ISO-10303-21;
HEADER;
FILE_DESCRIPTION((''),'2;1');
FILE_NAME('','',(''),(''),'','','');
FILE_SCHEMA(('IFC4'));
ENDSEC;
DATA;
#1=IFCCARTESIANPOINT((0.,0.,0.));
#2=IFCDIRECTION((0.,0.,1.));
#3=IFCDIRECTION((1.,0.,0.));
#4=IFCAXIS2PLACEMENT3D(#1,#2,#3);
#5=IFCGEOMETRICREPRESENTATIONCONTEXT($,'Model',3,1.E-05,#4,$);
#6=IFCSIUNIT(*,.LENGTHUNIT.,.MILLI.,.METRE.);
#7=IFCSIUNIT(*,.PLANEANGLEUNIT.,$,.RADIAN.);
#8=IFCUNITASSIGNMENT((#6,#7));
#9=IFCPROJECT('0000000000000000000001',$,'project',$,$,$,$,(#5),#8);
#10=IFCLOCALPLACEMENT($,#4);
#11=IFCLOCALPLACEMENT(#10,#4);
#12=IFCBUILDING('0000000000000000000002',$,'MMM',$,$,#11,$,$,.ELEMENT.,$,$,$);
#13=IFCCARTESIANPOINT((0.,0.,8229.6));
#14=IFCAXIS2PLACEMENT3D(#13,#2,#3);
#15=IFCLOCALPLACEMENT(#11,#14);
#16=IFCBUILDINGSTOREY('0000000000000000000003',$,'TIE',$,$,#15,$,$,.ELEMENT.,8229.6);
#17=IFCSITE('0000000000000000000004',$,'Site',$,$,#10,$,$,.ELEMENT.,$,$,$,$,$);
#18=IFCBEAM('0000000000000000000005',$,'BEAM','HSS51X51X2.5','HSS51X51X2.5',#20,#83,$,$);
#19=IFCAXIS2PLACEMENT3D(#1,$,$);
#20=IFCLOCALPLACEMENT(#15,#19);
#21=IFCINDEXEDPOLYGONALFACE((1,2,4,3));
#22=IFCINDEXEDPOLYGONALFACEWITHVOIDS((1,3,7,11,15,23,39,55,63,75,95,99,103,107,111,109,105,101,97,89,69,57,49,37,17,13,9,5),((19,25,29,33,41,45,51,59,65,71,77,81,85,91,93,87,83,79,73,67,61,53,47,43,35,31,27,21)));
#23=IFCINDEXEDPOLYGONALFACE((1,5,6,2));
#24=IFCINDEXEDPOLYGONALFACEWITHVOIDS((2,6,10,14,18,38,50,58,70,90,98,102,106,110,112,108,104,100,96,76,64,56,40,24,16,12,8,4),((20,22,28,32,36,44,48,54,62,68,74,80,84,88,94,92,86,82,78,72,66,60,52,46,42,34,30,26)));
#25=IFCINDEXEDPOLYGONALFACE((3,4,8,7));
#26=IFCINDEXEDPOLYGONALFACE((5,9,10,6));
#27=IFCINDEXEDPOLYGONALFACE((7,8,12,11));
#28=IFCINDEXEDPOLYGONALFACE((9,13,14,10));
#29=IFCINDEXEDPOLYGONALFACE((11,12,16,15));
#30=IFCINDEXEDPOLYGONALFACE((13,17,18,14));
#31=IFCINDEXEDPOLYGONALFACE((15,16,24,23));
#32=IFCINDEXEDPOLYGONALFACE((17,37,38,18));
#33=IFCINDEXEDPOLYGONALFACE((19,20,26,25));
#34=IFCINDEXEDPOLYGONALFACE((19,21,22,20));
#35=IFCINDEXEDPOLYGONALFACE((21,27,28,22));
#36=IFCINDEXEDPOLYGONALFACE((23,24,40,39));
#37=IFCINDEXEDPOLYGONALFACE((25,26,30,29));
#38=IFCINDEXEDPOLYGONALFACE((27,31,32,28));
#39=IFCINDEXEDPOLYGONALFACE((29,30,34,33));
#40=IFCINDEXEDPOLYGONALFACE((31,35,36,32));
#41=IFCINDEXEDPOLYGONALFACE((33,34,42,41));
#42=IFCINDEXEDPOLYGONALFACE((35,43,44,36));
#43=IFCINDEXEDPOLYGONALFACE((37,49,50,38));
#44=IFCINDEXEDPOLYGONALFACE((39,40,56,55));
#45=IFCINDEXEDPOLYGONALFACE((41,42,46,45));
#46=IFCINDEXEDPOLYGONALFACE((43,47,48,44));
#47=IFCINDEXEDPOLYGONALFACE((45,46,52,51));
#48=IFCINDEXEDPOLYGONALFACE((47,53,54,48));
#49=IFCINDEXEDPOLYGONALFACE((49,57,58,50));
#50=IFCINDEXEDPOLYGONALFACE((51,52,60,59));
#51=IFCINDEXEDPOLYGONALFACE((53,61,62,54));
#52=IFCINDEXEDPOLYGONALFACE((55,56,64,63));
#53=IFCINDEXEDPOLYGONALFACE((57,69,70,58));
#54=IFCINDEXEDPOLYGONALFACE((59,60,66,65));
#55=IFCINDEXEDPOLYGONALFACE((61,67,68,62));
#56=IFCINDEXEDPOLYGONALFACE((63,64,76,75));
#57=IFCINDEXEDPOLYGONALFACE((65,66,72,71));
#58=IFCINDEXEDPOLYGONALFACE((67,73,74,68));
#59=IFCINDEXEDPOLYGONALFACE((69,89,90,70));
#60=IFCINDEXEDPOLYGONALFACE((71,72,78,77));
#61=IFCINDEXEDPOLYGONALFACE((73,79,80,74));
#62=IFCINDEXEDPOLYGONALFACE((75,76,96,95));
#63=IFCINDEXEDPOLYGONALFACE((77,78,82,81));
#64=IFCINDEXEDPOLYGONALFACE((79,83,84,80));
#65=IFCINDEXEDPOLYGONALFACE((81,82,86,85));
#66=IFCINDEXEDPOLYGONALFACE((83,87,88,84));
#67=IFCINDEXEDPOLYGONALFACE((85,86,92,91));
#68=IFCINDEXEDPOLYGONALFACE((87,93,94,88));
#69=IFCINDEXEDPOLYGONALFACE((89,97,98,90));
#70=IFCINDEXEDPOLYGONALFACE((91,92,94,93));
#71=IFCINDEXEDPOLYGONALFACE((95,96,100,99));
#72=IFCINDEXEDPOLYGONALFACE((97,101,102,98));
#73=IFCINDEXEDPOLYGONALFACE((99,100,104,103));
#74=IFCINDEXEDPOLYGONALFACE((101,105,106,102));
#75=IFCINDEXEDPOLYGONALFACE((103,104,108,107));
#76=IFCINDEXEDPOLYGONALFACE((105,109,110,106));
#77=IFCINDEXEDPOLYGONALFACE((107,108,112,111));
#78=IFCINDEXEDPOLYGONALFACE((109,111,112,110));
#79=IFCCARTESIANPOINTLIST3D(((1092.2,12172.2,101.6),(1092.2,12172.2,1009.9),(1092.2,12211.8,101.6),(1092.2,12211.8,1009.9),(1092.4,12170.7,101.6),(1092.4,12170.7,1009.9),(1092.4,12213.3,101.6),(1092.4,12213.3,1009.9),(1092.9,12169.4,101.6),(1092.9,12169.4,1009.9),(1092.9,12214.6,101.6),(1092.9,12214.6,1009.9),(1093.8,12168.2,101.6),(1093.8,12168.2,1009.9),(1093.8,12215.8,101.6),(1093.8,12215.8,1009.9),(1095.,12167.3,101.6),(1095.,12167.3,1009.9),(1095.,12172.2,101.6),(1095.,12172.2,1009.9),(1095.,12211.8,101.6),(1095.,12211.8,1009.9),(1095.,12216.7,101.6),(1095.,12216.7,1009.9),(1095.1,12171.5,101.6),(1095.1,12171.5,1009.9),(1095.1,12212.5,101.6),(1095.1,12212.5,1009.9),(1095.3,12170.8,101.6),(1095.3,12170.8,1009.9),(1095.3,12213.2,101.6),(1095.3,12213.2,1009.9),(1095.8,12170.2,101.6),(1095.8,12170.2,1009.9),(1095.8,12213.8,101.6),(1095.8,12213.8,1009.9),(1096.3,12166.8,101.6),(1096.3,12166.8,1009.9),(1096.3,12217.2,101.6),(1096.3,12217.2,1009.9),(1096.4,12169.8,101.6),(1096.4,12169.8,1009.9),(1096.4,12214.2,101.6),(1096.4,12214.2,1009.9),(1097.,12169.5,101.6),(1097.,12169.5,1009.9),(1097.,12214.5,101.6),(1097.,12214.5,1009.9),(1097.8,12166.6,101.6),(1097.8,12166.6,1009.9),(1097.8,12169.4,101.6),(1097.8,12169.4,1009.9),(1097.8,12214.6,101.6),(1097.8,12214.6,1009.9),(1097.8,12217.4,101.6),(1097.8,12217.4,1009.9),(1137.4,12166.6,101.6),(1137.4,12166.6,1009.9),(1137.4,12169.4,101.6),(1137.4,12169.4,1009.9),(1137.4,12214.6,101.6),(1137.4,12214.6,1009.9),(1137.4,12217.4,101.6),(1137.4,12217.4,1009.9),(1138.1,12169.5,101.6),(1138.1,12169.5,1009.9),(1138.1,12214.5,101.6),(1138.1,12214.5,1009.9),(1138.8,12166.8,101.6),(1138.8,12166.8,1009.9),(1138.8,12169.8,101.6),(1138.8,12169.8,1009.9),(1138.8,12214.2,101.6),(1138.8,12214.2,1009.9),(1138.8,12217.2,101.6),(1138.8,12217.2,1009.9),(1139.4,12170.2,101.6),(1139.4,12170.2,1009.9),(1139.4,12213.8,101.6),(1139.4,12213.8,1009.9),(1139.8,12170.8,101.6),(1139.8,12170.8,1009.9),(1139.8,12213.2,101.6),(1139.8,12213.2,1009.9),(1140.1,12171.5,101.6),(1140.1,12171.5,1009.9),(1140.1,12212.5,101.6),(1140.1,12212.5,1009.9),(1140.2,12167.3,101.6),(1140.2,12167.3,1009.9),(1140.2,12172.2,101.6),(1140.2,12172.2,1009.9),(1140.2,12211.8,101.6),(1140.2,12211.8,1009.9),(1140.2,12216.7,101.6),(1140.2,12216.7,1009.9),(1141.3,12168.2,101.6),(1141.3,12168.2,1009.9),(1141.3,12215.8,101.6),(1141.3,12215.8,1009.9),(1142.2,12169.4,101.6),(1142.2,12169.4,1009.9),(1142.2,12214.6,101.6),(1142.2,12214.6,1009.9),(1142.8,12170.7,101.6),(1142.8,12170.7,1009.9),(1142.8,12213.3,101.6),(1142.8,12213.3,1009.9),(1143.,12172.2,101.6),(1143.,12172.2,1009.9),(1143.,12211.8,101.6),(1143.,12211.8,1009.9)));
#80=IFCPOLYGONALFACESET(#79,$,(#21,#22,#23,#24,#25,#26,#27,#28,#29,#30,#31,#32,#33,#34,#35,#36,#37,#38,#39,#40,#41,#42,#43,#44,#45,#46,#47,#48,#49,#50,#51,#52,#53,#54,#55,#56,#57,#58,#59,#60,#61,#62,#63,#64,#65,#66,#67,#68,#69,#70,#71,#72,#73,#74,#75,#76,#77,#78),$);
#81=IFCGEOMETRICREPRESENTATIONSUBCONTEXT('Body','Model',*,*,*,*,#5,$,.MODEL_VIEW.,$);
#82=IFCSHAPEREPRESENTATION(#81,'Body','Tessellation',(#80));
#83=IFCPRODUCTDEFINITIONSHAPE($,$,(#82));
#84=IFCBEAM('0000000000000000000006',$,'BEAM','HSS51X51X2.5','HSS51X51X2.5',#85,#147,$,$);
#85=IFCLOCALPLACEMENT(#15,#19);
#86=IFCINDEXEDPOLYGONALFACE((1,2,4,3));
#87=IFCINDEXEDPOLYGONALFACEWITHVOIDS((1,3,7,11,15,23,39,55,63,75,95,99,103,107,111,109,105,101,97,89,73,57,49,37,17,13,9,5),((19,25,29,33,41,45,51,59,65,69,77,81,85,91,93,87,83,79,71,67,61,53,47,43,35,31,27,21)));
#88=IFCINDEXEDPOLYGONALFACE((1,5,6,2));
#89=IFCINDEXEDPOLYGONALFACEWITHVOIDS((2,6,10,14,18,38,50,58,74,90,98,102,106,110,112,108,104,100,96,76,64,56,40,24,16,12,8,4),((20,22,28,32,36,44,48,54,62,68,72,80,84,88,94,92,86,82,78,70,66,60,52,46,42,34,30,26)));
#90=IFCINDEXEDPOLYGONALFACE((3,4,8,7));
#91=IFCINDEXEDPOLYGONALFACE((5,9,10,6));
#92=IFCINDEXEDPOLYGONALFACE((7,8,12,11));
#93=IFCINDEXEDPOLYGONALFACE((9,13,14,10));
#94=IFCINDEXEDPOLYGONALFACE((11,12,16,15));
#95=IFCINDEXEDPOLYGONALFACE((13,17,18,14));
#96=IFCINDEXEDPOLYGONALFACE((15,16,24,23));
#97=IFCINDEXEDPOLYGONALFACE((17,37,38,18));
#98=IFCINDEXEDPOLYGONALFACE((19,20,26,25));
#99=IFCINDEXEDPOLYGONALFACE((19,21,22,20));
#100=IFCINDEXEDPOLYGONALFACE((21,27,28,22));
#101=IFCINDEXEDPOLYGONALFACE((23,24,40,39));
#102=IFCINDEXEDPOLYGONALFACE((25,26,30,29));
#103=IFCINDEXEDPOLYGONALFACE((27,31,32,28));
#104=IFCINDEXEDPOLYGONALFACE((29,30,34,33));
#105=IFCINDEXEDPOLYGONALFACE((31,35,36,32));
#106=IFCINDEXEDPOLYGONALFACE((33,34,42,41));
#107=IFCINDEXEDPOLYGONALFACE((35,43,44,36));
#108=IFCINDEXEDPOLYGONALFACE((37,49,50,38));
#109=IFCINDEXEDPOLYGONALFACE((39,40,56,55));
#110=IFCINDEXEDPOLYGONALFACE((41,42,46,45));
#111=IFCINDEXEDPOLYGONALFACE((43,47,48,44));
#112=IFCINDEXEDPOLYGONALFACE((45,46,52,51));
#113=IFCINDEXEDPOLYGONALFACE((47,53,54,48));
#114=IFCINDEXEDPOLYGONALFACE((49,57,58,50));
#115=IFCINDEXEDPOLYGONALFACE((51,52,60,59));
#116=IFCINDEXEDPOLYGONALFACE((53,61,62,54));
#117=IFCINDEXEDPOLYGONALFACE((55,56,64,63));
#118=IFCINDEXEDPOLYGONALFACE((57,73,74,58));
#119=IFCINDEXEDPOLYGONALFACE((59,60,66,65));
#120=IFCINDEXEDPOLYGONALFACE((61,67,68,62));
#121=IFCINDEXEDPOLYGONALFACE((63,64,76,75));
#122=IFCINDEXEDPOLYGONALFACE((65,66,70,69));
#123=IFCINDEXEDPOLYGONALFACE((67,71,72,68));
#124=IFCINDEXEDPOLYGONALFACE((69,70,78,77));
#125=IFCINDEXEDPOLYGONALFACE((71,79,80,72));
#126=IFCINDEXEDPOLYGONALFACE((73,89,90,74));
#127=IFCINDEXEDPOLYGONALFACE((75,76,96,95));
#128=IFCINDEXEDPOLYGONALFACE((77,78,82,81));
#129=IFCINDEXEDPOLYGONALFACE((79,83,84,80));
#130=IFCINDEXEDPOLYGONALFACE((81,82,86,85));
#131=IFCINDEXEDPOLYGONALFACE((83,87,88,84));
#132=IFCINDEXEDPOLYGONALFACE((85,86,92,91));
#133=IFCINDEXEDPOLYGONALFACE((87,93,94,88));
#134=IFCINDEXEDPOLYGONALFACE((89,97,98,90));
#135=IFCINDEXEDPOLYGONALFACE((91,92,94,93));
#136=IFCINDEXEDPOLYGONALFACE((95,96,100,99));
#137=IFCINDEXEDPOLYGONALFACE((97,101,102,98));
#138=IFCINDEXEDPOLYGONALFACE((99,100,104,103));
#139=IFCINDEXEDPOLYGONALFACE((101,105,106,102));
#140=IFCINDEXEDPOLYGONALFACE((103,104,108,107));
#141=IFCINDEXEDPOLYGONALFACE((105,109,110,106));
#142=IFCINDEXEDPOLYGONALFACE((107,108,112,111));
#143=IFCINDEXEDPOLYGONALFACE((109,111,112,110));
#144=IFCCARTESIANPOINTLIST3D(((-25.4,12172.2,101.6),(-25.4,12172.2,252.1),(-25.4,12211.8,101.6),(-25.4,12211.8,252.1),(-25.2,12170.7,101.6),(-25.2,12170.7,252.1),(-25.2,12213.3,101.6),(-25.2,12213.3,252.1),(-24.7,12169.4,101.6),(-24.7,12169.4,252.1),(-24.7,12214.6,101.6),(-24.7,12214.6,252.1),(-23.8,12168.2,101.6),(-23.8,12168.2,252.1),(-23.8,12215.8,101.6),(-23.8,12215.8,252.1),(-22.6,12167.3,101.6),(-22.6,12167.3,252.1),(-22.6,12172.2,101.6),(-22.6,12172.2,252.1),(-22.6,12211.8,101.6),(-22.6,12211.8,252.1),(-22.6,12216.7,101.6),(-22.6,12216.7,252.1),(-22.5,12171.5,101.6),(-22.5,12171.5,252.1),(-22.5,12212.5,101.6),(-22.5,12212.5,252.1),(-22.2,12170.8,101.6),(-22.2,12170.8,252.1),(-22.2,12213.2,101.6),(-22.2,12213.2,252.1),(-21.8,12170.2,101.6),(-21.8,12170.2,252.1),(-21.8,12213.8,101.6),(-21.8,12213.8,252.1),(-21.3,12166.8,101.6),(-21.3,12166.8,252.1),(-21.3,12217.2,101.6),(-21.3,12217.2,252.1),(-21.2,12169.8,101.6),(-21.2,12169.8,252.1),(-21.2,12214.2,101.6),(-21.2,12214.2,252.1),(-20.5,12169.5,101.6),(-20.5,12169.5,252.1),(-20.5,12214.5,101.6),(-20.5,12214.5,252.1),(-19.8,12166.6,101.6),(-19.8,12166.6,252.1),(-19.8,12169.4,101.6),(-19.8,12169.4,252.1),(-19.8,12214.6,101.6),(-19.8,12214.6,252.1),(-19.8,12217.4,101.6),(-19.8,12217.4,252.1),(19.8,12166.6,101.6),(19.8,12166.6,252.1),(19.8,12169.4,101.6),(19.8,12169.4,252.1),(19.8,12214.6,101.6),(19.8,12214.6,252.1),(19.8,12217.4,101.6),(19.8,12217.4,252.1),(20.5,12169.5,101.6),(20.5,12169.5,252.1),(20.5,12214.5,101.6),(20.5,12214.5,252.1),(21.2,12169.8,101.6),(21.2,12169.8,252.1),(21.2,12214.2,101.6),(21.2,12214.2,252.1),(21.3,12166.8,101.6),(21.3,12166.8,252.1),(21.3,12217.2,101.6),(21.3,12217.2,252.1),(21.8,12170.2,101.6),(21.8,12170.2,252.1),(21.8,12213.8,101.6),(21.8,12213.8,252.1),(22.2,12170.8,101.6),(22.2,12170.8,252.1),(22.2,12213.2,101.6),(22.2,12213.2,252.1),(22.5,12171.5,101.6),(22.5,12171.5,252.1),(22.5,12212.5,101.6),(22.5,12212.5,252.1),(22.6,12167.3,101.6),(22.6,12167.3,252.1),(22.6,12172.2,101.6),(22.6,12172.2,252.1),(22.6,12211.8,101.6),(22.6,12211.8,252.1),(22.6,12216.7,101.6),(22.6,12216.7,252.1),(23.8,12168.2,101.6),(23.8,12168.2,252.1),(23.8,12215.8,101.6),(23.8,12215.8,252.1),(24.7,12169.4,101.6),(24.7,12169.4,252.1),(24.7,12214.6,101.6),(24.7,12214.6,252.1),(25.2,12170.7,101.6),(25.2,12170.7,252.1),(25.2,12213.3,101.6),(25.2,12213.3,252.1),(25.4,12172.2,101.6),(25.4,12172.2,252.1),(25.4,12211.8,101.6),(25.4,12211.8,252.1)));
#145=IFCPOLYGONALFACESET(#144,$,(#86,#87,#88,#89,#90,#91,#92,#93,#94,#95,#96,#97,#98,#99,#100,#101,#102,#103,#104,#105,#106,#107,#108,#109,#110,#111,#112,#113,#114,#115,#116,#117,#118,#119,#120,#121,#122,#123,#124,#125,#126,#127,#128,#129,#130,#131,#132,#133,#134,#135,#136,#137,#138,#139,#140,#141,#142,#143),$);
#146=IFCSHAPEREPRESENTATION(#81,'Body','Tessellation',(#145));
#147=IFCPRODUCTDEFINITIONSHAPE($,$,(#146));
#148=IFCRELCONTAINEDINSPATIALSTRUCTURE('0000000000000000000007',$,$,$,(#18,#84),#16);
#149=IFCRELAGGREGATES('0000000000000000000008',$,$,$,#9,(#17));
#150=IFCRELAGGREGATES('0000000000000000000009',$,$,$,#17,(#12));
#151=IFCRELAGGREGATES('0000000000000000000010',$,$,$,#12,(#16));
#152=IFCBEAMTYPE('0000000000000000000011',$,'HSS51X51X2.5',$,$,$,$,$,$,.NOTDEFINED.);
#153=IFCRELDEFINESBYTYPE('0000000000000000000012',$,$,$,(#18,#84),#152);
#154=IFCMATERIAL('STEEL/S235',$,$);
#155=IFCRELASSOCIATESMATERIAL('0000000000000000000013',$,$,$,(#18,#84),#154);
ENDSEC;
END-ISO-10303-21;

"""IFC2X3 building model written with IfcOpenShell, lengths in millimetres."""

from ifc_helpers import new_model, si_unit, frame, origin_with_axes, origin_2d_with_axis, place, context, subcontext, project, spatial, hollow_rectangle, extrude, material, type_object, element, save


model = new_model("IFC2X3")

# Units and contexts
model_context = context("Model", 3, precision=1e-05, world=origin_with_axes())
body_context = subcontext(model_context, "Body", "Model", "MODEL_VIEW")
ifc_project = project(units=[si_unit("LENGTHUNIT", "METRE", prefix="MILLI"), si_unit("PLANEANGLEUNIT", "RADIAN")], contexts=[model_context])

# Site, building, storey
site_placement = place(None, origin_with_axes())
site = spatial("IfcSite", under=ifc_project, at=site_placement, Name="Site", CompositionType="ELEMENT")
building_placement = place(site_placement, origin_with_axes())
building = spatial("IfcBuilding", under=site, at=building_placement, Name="MMM", CompositionType="ELEMENT")
storey_placement = place(building_placement, frame((0.0, 0.0, 8229.6), z_axis=(0.0, 0.0, 1.0), x_axis=(1.0, 0.0, 0.0)))
storey = spatial("IfcBuildingStorey", under=building, at=storey_placement, Name="TIE", CompositionType="ELEMENT", Elevation=8229.6)

# Beams
ifc_material = material(Name="STEEL/S235")
beam_type_1 = type_object("IfcBeamType", Name="HSS51X51X2.5", PredefinedType="NOTDEFINED")
beam_1_placement = place(storey_placement, frame((1117.6, 12192.0, 1009.9), z_axis=(1.0, 0.0, 0.0), x_axis=(0.0, 0.0, -1.0)))
element("IfcBeam", 1, at=beam_1_placement, inside=storey, type_object=beam_type_1, material=ifc_material, Name="BEAM", Description="HSS51X51X2.5", ObjectType="HSS51X51X2.5", context=body_context, shape_type="SweptSolid", body=[
    extrude(hollow_rectangle(XDim=50.8, YDim=50.8, WallThickness=2.8, InnerFilletRadius=2.8, OuterFilletRadius=5.6, at=origin_2d_with_axis()), frame((908.3, 0.0, 0.0), z_axis=(-1.0, 0.0, 0.0), x_axis=(0.0, -1.0, 0.0)), (0.0, 0.0, 1.0), 908.3),
])
beam_2_placement = place(storey_placement, frame((0.0, 12192.0, 252.1), z_axis=(1.0, 0.0, 0.0), x_axis=(0.0, 0.0, -1.0)))
element("IfcBeam", 2, at=beam_2_placement, inside=storey, type_object=beam_type_1, material=ifc_material, Name="BEAM", Description="HSS51X51X2.5", ObjectType="HSS51X51X2.5", context=body_context, shape_type="SweptSolid", body=[
    extrude(hollow_rectangle(XDim=50.8, YDim=50.8, WallThickness=2.8, InnerFilletRadius=2.8, OuterFilletRadius=5.6, at=origin_2d_with_axis()), frame((150.5, 0.0, 0.0), z_axis=(-1.0, 0.0, 0.0), x_axis=(0.0, -1.0, 0.0)), (0.0, 0.0, 1.0), 150.5),
])

save(model, "model.ifc")
